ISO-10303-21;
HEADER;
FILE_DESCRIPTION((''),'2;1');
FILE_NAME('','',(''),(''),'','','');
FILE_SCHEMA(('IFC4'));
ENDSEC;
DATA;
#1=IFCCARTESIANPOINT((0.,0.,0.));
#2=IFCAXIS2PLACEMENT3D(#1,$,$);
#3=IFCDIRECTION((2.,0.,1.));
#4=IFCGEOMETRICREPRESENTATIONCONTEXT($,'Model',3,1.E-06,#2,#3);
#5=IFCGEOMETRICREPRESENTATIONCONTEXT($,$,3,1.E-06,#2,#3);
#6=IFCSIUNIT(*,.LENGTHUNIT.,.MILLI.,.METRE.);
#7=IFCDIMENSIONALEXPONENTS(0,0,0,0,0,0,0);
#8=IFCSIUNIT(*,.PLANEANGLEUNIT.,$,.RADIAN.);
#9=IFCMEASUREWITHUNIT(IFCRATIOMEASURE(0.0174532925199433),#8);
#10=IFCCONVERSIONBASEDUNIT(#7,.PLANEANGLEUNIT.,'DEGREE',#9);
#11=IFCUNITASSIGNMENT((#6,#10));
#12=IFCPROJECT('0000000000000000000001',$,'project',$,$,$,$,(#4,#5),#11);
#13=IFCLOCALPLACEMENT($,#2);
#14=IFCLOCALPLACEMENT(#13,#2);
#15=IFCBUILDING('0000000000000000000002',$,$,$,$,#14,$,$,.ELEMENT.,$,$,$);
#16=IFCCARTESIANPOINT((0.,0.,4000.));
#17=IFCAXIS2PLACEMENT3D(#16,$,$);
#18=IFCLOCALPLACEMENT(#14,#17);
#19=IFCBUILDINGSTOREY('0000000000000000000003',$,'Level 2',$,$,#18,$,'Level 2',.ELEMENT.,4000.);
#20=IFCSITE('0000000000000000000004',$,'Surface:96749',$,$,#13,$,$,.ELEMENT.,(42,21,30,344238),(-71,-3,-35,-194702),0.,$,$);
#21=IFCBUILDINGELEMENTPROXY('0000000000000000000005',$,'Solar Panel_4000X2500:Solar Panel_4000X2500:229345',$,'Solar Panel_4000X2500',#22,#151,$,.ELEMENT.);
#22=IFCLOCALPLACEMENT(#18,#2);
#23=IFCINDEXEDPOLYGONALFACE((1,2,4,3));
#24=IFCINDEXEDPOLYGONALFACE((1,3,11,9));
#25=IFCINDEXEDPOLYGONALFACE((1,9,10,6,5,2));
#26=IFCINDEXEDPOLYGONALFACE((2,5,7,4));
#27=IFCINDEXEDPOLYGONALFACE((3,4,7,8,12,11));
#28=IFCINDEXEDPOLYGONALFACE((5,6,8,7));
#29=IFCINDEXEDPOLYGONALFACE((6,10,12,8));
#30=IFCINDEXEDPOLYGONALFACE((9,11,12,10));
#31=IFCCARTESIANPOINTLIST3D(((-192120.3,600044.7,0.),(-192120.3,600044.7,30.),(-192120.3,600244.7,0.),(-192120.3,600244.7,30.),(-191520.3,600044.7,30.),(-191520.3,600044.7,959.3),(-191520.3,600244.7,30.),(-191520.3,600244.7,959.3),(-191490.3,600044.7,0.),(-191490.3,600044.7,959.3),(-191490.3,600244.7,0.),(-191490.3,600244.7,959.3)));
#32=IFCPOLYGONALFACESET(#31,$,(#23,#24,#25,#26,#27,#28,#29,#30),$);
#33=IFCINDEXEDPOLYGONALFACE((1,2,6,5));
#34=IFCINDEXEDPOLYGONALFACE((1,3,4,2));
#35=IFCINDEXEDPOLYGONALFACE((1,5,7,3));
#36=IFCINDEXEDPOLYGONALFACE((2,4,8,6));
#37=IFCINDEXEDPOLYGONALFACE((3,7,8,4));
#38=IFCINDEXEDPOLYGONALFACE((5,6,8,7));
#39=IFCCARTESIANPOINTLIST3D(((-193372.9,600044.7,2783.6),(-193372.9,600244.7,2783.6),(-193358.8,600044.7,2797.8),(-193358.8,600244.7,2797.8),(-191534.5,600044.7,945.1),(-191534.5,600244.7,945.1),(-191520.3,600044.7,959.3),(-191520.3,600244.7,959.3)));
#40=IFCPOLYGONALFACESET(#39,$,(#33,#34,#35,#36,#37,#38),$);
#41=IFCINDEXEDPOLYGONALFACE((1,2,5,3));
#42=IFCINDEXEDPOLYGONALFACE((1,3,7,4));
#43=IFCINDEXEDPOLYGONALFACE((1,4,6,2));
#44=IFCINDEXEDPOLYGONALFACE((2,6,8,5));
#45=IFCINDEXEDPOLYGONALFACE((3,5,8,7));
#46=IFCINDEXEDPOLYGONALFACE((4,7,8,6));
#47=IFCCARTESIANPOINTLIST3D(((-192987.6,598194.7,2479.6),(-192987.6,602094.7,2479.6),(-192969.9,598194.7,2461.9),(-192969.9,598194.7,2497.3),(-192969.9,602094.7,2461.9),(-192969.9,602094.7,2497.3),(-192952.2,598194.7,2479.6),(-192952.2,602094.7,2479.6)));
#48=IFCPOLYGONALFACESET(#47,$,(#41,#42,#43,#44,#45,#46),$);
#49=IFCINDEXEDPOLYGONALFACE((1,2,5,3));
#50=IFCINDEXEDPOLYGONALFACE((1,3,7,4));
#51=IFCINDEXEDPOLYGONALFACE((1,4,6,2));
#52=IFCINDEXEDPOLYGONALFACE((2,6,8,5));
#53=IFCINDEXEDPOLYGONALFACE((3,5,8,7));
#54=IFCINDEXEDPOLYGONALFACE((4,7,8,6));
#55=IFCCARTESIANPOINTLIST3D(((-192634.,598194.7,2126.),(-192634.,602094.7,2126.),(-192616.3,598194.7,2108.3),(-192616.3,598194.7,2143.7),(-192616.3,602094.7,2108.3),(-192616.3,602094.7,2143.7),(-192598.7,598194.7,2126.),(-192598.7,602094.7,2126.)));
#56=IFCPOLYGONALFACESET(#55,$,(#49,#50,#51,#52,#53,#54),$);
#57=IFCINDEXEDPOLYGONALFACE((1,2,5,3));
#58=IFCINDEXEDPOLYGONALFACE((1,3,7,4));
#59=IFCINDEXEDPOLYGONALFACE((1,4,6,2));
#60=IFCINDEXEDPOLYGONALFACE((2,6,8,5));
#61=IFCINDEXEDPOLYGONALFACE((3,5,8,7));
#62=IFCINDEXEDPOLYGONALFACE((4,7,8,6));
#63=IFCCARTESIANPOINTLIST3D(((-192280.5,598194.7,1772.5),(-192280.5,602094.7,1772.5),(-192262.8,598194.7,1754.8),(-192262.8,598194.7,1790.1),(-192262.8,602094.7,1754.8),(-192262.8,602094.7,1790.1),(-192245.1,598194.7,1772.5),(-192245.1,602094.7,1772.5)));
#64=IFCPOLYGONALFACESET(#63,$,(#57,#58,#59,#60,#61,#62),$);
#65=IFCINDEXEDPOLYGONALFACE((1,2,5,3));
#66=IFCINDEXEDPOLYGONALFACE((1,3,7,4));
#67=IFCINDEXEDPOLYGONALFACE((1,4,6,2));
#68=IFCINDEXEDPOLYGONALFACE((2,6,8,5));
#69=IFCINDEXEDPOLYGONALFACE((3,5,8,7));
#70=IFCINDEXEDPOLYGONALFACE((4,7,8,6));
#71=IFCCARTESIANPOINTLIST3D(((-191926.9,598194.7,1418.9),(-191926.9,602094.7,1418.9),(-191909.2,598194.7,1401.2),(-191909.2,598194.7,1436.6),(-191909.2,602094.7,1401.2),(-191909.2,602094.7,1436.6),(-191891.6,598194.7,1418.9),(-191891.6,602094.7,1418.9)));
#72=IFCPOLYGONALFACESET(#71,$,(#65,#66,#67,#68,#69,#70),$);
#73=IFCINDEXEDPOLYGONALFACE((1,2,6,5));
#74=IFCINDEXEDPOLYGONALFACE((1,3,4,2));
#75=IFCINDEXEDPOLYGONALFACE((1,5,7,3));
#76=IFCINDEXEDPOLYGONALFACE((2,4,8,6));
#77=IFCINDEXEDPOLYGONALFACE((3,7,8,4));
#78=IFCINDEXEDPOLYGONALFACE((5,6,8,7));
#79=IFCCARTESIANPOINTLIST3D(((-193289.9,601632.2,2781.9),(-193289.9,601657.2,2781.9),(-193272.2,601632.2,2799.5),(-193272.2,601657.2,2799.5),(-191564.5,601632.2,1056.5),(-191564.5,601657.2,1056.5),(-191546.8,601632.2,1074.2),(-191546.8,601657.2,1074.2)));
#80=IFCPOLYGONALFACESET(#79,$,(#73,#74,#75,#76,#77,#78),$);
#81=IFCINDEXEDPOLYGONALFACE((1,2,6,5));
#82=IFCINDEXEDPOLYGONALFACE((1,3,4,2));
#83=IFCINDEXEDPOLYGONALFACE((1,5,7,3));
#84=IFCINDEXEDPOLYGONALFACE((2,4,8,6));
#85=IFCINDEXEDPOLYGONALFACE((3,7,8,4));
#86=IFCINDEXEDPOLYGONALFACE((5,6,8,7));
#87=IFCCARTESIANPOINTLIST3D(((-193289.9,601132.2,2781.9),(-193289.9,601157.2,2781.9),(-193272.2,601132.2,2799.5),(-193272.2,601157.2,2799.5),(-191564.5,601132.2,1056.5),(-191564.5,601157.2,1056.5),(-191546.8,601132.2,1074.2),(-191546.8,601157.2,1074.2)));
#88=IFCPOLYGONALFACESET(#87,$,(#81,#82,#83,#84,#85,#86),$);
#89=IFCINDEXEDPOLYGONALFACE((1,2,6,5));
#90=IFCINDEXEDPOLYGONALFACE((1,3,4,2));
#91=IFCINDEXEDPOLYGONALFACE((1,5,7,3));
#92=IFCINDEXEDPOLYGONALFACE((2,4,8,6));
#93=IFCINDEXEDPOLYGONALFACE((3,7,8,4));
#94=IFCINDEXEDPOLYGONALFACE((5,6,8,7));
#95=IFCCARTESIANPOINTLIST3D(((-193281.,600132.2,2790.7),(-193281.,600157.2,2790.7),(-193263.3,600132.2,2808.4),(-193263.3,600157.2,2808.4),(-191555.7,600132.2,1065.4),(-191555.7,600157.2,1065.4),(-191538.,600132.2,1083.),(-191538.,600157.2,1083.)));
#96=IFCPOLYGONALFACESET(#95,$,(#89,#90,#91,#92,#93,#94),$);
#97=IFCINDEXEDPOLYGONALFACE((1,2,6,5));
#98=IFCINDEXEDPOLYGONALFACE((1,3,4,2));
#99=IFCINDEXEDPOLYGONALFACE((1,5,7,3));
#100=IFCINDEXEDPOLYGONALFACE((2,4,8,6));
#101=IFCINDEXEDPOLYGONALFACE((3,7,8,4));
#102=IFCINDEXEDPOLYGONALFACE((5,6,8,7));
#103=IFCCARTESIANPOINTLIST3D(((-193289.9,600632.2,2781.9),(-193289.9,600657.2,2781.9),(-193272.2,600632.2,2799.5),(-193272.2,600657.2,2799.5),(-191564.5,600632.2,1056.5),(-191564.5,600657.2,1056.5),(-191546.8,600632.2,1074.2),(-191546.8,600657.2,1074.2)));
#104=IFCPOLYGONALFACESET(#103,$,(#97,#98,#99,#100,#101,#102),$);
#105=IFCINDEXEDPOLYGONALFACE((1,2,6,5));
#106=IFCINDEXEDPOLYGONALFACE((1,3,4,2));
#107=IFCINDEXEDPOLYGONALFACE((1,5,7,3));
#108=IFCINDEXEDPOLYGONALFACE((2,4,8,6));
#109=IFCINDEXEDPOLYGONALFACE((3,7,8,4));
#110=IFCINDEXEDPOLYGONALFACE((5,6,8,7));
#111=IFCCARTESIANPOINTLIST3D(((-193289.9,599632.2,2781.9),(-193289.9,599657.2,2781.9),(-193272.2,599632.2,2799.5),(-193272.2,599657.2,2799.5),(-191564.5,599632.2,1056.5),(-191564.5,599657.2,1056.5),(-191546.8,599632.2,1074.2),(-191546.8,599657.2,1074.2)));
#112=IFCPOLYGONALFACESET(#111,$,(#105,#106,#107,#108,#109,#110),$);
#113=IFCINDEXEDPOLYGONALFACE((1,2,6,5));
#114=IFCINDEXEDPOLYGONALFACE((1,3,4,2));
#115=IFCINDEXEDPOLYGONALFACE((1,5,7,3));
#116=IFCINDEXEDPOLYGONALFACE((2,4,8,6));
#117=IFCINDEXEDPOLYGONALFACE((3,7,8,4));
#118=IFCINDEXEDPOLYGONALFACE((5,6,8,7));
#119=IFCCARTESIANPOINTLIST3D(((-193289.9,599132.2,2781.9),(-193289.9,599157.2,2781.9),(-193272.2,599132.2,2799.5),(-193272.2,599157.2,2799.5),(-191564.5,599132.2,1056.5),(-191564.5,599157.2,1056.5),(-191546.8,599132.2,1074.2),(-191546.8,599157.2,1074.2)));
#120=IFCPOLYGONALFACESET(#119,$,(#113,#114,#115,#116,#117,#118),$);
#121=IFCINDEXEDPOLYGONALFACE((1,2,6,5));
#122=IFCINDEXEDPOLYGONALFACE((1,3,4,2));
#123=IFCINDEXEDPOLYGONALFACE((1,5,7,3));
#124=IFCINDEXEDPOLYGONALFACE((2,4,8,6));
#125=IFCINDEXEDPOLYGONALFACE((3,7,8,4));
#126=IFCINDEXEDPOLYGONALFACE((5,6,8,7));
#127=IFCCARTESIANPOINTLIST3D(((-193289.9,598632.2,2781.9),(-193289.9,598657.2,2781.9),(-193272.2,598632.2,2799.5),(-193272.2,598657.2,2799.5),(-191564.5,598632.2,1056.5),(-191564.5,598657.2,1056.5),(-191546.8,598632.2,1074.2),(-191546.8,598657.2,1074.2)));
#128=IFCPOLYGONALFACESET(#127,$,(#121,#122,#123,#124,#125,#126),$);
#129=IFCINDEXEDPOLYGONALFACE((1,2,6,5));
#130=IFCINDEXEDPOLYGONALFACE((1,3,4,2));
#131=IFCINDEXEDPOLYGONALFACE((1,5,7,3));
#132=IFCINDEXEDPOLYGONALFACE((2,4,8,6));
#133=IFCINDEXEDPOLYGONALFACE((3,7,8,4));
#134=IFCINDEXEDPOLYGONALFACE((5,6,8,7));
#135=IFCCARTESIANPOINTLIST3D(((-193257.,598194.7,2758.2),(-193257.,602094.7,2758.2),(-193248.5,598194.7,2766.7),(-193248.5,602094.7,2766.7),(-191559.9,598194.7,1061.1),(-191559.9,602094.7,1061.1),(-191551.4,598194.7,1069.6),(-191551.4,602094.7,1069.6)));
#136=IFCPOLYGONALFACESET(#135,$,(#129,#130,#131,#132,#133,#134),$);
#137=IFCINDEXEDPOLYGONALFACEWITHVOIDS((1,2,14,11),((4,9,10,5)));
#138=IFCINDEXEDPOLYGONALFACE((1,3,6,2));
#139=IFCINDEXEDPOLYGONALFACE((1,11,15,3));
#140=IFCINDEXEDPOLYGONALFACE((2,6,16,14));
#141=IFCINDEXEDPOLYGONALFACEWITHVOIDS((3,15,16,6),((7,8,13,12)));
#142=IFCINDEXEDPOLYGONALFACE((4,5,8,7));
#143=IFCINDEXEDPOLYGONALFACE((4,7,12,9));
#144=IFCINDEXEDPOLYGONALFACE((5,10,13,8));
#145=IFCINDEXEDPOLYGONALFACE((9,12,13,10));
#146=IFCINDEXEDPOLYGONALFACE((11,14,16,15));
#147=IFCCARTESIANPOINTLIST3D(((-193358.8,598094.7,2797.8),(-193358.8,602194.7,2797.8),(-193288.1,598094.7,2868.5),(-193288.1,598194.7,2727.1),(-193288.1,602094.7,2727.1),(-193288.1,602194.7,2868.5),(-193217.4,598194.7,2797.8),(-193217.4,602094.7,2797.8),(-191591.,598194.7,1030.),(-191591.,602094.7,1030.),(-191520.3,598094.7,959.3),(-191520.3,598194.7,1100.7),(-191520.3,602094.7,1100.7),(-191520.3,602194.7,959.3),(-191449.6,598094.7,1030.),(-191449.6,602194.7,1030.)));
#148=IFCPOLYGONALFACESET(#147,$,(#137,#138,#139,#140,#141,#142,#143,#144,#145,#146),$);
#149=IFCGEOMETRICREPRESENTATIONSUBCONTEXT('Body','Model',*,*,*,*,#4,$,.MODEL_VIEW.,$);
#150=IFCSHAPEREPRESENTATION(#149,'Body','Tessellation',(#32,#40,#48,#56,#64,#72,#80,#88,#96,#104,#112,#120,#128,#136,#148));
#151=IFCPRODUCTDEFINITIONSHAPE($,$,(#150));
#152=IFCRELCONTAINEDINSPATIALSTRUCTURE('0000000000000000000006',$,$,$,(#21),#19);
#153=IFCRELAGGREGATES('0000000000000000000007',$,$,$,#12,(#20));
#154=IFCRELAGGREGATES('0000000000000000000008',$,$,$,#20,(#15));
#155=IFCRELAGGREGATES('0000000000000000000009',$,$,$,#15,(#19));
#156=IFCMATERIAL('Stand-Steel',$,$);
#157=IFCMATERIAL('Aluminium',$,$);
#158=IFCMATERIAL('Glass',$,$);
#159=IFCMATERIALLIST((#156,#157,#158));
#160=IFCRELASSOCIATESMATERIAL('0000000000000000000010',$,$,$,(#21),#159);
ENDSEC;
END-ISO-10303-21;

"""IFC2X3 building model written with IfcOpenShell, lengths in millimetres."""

from ifc_helpers import new_model, entity, si_unit, converted_unit, direction, frame, frame_2d, origin, origin_2d_with_axis, place, context, subcontext, project, spatial, polyline, rectangle, outline, extrude, source, transform, mapped, material, material_list, element, save


model = new_model("IFC2X3")

# Units and contexts
model_context = context("Model", 3, precision=1e-06, world=origin(), true_north=direction((2.0, 0.0, 1.0)))
context_of_model = context(None, 3, precision=1e-06, world=origin(), true_north=direction((2.0, 0.0, 1.0)))
body_context = subcontext(model_context, "Body", "Model", "MODEL_VIEW")
ifc_project = project(units=[si_unit("LENGTHUNIT", "METRE", prefix="MILLI"), converted_unit("PLANEANGLEUNIT", "DEGREE", entity("IfcRatioMeasure", 0.0174532925199433), si_unit("PLANEANGLEUNIT", "RADIAN"), dimensions=[0, 0, 0, 0, 0, 0, 0])], contexts=[model_context, context_of_model])

# Site, building, storey
site_placement = place(None, origin())
site = spatial("IfcSite", under=ifc_project, at=site_placement, Name="Surface:96749", CompositionType="ELEMENT", RefLatitude=(42, 21, 30, 344238), RefLongitude=(-71, -3, -35, -194702), RefElevation=0.0)
building_placement = place(site_placement, origin())
building = spatial("IfcBuilding", under=site, at=building_placement, CompositionType="ELEMENT")
storey_placement = place(building_placement, frame((0.0, 0.0, 4000.0)))
storey = spatial("IfcBuildingStorey", under=building, at=storey_placement, Name="Level 2", LongName="Level 2", CompositionType="ELEMENT", Elevation=4000.0)

# Building element proxy
ifc_material_1 = material(Name="Stand-Steel")
ifc_material_2 = material(Name="Aluminium")
ifc_material_3 = material(Name="Glass")
shared_shape = source(origin(), body_context, "Body", "SweptSolid", [
    extrude(outline(polyline([(-629.5, -220.0), (329.8, -220.0), (329.8, 410.0), (299.8, 410.0), (299.8, -190.0), (-629.5, -190.0), (-629.5, -220.0)])), frame((-190.0, -100.0, 299.8), z_axis=(0.0, 1.0, 0.0), x_axis=(0.0, 0.0, -1.0)), (0.0, 0.0, 1.0), 200.0),
    extrude(rectangle(XDim=20.0, YDim=200.0, at=frame_2d((0.0, 0.0), x_axis=(0.0, 1.0))), frame((-7.1, 0.0, 922.2), z_axis=(-0.707107, 0.0, 0.707107), x_axis=(0.0, 1.0, 0.0)), (0.0, 0.0, 1.0), 2600.0),
    extrude(rectangle(XDim=25.0, YDim=25.0, at=frame_2d((0.0, 0.0), x_axis=(1.0, 0.0))), frame((-1449.6, -1950.0, 2449.6), z_axis=(0.0, 1.0, 0.0), x_axis=(-0.707107, 0.0, -0.707107)), (0.0, 0.0, 1.0), 3900.0),
    extrude(rectangle(XDim=25.0, YDim=25.0, at=origin_2d_with_axis()), frame((-1096.0, -1950.0, 2096.0), z_axis=(0.0, 1.0, 0.0), x_axis=(-0.707107, 0.0, -0.707107)), (0.0, 0.0, 1.0), 3900.0),
    extrude(rectangle(XDim=25.0, YDim=25.0, at=origin_2d_with_axis()), frame((-742.5, -1950.0, 1742.5), z_axis=(0.0, 1.0, 0.0), x_axis=(-0.707107, 0.0, -0.707107)), (0.0, 0.0, 1.0), 3900.0),
    extrude(rectangle(XDim=25.0, YDim=25.0, at=frame_2d((0.0, 0.0), x_axis=(1.0, 0.0))), frame((-388.9, -1950.0, 1388.9), z_axis=(0.0, 1.0, 0.0), x_axis=(-0.707107, 0.0, -0.707107)), (0.0, 0.0, 1.0), 3900.0),
    extrude(rectangle(XDim=25.0, YDim=25.0, at=frame_2d((0.0, 0.0), x_axis=(0.0, 1.0))), frame((-35.4, 1500.0, 1035.4), z_axis=(-0.707107, 0.0, 0.707107), x_axis=(0.0, 1.0, 0.0)), (0.0, 0.0, 1.0), 2440.0),
    extrude(rectangle(XDim=25.0, YDim=25.0, at=frame_2d((0.0, 0.0), x_axis=(0.0, 1.0))), frame((-35.4, 1000.0, 1035.4), z_axis=(-0.707107, 0.0, 0.707107), x_axis=(0.0, 1.0, 0.0)), (0.0, 0.0, 1.0), 2440.0),
    extrude(rectangle(XDim=25.0, YDim=25.0, at=frame_2d((0.0, 0.0), x_axis=(0.0, 1.0))), frame((-26.5, 0.0, 1044.2), z_axis=(-0.707107, 0.0, 0.707107), x_axis=(0.0, -1.0, 0.0)), (0.0, 0.0, 1.0), 2440.0),
    extrude(rectangle(XDim=25.0, YDim=25.0, at=frame_2d((0.0, 0.0), x_axis=(0.0, 1.0))), frame((-35.4, 500.0, 1035.4), z_axis=(-0.707107, 0.0, 0.707107), x_axis=(0.0, 1.0, 0.0)), (0.0, 0.0, 1.0), 2440.0),
    extrude(rectangle(XDim=25.0, YDim=25.0, at=frame_2d((0.0, 0.0), x_axis=(0.0, 1.0))), frame((-35.4, -500.0, 1035.4), z_axis=(-0.707107, 0.0, 0.707107), x_axis=(0.0, 1.0, 0.0)), (0.0, 0.0, 1.0), 2440.0),
    extrude(rectangle(XDim=25.0, YDim=25.0, at=frame_2d((0.0, 0.0), x_axis=(0.0, 1.0))), frame((-35.4, -1000.0, 1035.4), z_axis=(-0.707107, 0.0, 0.707107), x_axis=(0.0, 1.0, 0.0)), (0.0, 0.0, 1.0), 2440.0),
    extrude(rectangle(XDim=25.0, YDim=25.0, at=frame_2d((0.0, 0.0), x_axis=(0.0, 1.0))), frame((-35.4, -1500.0, 1035.4), z_axis=(-0.707107, 0.0, 0.707107), x_axis=(0.0, 1.0, 0.0)), (0.0, 0.0, 1.0), 2440.0),
    extrude(rectangle(XDim=2400.0, YDim=12.0, at=frame_2d((0.0, 0.0), x_axis=(1.0, 0.0))), frame((-883.9, -1950.0, 1883.9), z_axis=(0.0, 1.0, 0.0), x_axis=(0.707107, 0.0, -0.707107)), (0.0, 0.0, 1.0), 3900.0),
    extrude(outline(polyline([(-2050.0, -1300.0), (2050.0, -1300.0), (2050.0, 1300.0), (-2050.0, 1300.0), (-2050.0, -1300.0)]), holes=[polyline([(1950.0, -1200.0), (-1950.0, -1200.0), (-1950.0, 1200.0), (1950.0, 1200.0), (1950.0, -1200.0)])]), frame((-919.2, 0.0, 1848.5), z_axis=(0.707107, 0.0, 0.707107), x_axis=(0.0, 1.0, 0.0)), (0.0, 0.0, 1.0), 100.0),
])
ifc_material_list_1 = material_list([ifc_material_1, ifc_material_2, ifc_material_3])
proxy_1_placement = place(storey_placement, frame((-191520.3, 600144.7, 30.0)))
element("IfcBuildingElementProxy", 1, at=proxy_1_placement, inside=storey, material=ifc_material_list_1, Name="Solar Panel_4000X2500:Solar Panel_4000X2500:229345", ObjectType="Solar Panel_4000X2500", CompositionType="ELEMENT", context=body_context, shape_type="MappedRepresentation", body=[
    mapped(shared_shape, transform((0.0, 0.0, 0.0), scale=1.0)),
])

save(model, "model.ifc")
